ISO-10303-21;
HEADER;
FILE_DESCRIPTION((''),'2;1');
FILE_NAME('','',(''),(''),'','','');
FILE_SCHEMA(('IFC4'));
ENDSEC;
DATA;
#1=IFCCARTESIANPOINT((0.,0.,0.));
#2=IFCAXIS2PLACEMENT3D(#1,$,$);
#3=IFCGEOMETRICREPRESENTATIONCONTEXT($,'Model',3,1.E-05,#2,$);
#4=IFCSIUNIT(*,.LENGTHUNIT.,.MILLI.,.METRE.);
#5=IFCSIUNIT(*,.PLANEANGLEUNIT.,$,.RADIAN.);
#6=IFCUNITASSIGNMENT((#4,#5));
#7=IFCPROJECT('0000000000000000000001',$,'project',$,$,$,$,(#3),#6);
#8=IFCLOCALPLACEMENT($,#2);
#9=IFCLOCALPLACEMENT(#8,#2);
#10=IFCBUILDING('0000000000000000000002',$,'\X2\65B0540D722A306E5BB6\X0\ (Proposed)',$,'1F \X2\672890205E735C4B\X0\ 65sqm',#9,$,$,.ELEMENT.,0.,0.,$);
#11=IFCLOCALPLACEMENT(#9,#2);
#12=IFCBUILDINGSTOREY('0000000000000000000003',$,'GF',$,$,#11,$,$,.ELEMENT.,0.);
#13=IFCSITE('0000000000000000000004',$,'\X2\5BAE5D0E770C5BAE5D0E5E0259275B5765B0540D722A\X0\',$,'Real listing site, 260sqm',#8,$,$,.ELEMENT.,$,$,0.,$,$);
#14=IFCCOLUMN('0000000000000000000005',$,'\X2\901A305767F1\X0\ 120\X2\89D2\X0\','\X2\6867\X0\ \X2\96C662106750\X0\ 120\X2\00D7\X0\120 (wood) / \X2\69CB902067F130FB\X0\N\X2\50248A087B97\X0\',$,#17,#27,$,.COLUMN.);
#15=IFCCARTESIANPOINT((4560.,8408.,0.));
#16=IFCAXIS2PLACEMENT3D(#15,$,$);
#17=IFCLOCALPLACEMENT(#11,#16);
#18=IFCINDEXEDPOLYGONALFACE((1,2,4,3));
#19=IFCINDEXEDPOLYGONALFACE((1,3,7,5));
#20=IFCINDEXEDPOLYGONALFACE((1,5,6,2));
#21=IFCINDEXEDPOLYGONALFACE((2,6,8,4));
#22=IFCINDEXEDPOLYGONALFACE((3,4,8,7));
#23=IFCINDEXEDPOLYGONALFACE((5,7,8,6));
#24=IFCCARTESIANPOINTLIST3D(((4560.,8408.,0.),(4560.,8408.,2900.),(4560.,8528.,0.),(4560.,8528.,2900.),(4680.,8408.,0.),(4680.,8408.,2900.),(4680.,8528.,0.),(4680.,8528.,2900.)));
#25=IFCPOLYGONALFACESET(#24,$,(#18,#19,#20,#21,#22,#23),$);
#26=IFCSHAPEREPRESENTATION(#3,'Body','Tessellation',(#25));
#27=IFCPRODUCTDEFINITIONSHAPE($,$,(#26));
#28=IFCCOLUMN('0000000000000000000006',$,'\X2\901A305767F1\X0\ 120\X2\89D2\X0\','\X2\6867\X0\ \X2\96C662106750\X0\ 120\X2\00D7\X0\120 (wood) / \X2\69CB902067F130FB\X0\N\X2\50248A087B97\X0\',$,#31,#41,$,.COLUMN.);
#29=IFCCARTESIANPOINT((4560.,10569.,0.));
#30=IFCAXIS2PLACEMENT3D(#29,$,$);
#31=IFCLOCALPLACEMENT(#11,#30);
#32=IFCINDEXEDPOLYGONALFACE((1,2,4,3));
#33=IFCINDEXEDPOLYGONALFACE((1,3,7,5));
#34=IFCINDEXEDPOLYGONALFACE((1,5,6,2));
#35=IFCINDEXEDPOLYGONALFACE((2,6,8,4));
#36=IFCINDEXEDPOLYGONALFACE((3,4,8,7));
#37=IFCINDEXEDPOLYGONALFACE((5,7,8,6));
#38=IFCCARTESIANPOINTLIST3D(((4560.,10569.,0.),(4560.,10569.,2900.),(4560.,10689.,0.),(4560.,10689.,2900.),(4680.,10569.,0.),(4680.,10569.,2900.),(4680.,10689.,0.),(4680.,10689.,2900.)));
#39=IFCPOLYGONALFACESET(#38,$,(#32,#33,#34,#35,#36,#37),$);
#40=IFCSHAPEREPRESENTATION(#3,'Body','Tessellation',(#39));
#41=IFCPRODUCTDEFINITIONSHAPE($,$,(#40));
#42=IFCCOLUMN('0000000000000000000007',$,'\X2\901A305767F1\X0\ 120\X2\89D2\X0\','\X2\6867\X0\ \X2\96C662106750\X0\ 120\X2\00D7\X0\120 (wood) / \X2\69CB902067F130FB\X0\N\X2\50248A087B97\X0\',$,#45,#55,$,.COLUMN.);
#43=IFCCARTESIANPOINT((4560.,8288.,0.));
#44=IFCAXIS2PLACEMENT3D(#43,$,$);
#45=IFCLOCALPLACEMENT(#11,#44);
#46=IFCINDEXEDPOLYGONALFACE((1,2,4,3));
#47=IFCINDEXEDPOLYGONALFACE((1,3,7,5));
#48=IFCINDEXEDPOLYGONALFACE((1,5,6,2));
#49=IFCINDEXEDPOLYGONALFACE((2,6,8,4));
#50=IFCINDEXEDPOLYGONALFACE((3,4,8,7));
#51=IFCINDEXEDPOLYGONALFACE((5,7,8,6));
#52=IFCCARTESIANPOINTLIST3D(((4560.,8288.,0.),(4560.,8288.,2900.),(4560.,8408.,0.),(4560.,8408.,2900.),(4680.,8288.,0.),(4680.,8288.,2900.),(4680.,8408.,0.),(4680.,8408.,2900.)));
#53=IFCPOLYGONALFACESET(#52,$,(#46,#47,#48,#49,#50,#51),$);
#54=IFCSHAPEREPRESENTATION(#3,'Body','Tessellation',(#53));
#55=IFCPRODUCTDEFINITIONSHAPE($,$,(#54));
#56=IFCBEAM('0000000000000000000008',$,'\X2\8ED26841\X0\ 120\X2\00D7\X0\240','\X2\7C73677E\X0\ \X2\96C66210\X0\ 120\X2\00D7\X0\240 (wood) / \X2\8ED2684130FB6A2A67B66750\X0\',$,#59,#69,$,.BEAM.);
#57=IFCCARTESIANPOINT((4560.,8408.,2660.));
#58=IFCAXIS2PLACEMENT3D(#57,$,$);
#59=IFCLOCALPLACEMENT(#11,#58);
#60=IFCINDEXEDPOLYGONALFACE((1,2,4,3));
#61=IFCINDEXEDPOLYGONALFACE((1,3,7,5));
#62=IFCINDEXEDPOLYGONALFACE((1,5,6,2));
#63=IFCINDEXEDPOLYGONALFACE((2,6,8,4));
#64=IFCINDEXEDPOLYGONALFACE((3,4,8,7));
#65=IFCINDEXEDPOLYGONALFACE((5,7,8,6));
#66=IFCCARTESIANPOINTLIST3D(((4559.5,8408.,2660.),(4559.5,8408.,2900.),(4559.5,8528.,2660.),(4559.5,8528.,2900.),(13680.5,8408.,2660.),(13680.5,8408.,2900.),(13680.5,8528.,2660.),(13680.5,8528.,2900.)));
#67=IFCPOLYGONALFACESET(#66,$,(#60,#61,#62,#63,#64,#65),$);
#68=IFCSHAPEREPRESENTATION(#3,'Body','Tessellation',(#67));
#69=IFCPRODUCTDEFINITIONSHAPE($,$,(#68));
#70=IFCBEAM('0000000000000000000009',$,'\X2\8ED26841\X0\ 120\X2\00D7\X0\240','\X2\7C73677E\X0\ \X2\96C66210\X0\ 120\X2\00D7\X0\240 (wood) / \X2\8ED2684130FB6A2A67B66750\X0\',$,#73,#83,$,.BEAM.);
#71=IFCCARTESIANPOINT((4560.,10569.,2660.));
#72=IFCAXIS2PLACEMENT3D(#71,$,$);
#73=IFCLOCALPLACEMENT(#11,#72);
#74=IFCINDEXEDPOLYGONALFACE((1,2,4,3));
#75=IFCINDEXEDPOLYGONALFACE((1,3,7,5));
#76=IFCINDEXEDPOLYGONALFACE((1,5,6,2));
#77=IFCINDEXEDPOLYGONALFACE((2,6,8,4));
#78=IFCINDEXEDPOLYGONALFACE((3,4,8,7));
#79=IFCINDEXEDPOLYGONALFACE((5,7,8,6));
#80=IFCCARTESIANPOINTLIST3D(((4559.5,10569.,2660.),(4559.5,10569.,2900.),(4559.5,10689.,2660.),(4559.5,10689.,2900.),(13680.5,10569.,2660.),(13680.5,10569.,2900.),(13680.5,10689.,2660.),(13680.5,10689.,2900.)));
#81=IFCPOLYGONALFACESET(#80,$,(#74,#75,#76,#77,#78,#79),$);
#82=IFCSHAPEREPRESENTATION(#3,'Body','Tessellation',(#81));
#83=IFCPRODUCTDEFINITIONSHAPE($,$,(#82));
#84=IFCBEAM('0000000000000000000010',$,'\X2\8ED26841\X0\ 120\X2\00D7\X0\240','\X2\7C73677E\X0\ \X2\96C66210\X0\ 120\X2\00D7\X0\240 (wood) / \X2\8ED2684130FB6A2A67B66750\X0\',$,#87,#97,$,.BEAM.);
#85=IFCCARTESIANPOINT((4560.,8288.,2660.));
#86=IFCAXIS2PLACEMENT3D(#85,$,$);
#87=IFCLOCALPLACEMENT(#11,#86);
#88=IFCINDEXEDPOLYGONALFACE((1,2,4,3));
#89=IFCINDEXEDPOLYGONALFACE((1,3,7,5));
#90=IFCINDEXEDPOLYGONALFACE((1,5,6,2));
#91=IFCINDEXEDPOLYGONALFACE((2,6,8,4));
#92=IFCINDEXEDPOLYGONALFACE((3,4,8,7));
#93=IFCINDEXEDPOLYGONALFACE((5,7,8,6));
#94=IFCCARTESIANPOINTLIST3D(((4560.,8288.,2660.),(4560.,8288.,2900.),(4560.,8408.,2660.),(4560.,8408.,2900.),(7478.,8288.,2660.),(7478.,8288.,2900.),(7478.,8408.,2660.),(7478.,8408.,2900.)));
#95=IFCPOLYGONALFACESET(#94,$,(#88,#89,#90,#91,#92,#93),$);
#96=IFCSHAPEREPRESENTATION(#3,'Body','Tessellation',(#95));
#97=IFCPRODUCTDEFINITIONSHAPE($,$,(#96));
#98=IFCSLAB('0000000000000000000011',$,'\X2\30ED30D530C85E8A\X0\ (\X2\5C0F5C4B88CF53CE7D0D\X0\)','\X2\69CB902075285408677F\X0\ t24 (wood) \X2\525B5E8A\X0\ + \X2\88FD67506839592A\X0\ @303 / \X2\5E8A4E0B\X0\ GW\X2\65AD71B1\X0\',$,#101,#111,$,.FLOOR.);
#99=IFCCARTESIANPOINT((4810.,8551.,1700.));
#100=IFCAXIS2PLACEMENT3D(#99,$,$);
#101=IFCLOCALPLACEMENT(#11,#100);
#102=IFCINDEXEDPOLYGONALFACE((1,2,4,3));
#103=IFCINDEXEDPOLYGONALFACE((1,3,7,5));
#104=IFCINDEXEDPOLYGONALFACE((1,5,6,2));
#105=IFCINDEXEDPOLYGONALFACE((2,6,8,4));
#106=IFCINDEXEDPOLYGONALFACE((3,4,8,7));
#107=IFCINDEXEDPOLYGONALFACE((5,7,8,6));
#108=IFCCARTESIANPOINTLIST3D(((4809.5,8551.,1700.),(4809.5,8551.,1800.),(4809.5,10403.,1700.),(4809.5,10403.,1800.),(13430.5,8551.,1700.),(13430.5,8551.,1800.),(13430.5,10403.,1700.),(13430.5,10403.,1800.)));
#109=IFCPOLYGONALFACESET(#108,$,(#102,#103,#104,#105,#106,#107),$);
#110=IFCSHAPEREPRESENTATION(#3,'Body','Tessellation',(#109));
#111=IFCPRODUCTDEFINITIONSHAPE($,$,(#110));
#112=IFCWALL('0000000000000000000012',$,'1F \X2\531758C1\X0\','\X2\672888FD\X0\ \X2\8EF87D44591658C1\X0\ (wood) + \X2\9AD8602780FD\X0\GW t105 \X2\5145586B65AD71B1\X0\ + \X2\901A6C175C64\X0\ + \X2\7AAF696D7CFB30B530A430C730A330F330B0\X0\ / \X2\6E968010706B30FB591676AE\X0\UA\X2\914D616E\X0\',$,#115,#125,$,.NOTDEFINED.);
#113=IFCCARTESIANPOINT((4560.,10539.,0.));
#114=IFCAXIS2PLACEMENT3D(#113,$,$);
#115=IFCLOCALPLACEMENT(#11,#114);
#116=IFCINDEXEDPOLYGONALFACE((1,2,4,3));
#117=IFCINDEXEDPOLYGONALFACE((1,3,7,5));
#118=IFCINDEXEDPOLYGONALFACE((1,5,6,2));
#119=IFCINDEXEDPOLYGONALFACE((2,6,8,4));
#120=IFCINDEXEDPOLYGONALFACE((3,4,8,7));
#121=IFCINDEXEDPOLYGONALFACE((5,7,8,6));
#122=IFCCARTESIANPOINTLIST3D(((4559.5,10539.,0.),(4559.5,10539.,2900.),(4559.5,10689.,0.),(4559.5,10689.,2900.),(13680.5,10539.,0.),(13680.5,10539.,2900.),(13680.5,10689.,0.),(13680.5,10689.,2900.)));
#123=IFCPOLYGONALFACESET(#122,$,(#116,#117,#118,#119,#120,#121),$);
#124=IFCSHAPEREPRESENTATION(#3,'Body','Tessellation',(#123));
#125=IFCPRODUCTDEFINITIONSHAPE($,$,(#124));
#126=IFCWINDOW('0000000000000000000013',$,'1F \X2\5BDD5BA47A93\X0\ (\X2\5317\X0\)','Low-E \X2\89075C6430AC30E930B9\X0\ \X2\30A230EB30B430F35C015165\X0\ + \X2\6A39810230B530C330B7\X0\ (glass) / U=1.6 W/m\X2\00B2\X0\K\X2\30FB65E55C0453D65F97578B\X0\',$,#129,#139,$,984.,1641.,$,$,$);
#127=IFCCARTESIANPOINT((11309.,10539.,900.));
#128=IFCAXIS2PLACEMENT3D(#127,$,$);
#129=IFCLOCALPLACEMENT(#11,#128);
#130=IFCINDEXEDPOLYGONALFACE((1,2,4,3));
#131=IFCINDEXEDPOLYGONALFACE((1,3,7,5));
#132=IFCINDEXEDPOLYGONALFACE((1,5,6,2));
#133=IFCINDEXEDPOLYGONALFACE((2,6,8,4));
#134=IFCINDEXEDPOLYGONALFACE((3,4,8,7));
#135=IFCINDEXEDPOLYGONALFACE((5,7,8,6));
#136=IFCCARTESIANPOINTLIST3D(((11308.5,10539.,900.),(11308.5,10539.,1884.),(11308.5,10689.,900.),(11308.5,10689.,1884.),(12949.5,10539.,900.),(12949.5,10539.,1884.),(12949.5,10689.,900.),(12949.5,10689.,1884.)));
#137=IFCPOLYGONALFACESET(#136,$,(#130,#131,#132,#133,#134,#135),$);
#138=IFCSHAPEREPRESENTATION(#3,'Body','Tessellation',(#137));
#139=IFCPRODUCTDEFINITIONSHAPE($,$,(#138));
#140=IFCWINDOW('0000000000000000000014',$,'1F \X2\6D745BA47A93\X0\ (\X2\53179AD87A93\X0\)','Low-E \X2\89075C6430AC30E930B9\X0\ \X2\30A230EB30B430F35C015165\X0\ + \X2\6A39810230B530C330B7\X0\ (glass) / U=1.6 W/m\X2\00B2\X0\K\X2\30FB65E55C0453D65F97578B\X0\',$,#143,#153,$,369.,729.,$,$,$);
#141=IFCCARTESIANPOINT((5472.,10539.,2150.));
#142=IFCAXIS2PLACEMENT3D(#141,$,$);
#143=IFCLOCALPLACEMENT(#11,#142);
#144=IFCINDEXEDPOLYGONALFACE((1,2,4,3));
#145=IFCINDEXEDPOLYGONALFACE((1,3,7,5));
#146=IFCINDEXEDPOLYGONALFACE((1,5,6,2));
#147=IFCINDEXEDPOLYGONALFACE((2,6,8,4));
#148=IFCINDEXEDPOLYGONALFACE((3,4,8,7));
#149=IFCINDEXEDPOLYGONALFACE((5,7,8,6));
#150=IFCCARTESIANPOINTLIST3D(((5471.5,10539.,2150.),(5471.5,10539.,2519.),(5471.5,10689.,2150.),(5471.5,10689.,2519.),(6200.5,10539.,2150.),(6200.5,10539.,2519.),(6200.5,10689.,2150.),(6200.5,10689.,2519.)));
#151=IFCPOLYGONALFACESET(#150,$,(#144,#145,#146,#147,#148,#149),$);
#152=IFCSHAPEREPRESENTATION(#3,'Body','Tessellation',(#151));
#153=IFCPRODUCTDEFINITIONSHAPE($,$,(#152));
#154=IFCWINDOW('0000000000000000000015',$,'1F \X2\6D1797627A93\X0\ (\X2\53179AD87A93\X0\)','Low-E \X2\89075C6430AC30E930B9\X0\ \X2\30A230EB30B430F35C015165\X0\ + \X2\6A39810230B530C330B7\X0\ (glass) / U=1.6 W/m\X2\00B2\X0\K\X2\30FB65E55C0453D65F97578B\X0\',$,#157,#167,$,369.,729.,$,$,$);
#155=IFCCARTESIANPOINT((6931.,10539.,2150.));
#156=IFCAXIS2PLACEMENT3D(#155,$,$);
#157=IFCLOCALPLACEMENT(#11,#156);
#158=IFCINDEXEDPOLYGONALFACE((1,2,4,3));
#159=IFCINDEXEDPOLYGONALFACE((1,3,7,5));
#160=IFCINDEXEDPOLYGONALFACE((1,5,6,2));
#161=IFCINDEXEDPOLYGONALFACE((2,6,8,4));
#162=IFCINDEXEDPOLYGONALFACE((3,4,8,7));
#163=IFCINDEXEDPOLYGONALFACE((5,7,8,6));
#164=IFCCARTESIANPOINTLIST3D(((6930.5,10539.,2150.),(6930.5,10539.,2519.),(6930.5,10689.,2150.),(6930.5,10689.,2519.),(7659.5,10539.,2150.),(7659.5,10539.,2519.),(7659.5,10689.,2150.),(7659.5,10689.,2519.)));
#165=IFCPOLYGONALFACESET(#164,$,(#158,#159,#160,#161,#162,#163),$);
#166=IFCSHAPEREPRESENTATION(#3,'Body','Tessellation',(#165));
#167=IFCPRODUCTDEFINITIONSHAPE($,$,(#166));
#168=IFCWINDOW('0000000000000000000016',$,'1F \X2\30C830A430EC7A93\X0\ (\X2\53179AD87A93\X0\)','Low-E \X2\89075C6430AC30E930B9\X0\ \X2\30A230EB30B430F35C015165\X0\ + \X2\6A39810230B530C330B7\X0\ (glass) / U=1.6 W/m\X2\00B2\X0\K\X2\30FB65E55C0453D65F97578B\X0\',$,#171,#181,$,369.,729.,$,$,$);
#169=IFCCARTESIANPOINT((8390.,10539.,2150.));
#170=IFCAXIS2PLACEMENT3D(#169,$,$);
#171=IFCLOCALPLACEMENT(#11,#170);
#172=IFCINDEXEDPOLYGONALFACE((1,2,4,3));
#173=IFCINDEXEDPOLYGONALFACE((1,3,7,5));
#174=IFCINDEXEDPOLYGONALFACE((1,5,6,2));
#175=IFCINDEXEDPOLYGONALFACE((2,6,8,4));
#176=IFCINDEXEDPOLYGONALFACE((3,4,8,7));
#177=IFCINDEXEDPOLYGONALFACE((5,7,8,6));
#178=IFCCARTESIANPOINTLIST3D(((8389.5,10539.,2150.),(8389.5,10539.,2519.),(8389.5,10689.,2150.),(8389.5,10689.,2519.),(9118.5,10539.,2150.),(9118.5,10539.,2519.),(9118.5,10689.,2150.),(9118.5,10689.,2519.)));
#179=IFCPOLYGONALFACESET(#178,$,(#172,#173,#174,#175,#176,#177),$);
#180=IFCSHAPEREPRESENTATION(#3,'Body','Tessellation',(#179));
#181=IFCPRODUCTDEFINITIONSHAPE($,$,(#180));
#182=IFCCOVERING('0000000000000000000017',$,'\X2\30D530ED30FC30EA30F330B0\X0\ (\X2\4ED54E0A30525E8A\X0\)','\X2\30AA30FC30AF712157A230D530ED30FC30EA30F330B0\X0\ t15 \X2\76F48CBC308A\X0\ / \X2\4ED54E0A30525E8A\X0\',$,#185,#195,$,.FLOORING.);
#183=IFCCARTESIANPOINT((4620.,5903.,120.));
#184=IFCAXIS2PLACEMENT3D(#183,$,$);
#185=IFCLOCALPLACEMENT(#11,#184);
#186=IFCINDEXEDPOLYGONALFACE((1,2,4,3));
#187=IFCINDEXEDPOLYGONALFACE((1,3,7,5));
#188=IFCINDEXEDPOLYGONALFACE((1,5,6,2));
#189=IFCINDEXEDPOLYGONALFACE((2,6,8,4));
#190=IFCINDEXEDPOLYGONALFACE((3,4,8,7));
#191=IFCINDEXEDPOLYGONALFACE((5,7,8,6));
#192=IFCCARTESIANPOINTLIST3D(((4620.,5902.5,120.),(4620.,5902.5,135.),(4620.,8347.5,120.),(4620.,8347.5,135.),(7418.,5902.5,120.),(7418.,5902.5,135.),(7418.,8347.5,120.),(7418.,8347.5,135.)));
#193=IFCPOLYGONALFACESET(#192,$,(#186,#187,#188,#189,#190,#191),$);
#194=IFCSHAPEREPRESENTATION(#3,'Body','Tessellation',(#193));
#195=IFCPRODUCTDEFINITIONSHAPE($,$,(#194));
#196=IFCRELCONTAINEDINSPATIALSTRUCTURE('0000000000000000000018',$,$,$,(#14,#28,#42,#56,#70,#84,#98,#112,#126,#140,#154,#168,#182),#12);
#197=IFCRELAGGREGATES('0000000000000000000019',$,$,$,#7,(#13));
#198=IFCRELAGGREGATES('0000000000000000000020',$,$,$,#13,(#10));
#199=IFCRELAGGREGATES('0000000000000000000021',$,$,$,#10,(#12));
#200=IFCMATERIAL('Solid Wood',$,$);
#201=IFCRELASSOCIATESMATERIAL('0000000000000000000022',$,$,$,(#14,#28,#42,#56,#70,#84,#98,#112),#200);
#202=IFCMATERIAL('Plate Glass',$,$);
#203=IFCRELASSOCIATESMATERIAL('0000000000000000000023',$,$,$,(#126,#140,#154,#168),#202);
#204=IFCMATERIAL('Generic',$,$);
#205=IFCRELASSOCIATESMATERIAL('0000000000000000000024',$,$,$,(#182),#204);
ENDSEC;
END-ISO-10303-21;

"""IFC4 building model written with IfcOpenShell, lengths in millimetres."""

from ifc_helpers import new_model, si_unit, frame, frame_2d, origin, place, context, project, spatial, rectangle, extrude, material, element, fill, save


model = new_model("IFC4")

# Units and contexts
model_context = context("Model", 3, precision=1e-05, world=origin())
ifc_project = project(units=[si_unit("LENGTHUNIT", "METRE", prefix="MILLI"), si_unit("PLANEANGLEUNIT", "RADIAN")], contexts=[model_context])

# Site, building, storey
site_placement = place(None, origin())
site = spatial("IfcSite", under=ifc_project, at=site_placement, Name="宮崎県宮崎市大字新名爪", ObjectType="Real listing site, 260sqm", CompositionType="ELEMENT", RefElevation=0.0)
building_placement = place(site_placement, origin())
building = spatial("IfcBuilding", under=site, at=building_placement, Name="新名爪の家 (Proposed)", ObjectType="1F 木造平屋 65sqm", CompositionType="ELEMENT", ElevationOfRefHeight=0.0, ElevationOfTerrain=0.0)
storey_placement = place(building_placement, origin())
storey = spatial("IfcBuildingStorey", under=building, at=storey_placement, Name="GF", CompositionType="ELEMENT", Elevation=0.0)

# Columns
ifc_material_1 = material(Name="Solid Wood")
column_1_placement = place(storey_placement, frame((4560.0, 8408.0, 0.0)))
element("IfcColumn", 1, at=column_1_placement, inside=storey, material=ifc_material_1, Name="通し柱 120角", Description="桧 集成材 120×120 (wood) / 構造柱・N値計算", PredefinedType="COLUMN", context=model_context, shape_type="SweptSolid", body=[
    extrude(rectangle(XDim=120.0, YDim=120.0, at=frame_2d((60.0, 60.0))), frame((4560.0, 8408.0, 0.0)), (0.0, 0.0, 1.0), 2900.0),
])
column_2_placement = place(storey_placement, frame((4560.0, 10569.0, 0.0)))
element("IfcColumn", 2, at=column_2_placement, inside=storey, material=ifc_material_1, Name="通し柱 120角", Description="桧 集成材 120×120 (wood) / 構造柱・N値計算", PredefinedType="COLUMN", context=model_context, shape_type="SweptSolid", body=[
    extrude(rectangle(XDim=120.0, YDim=120.0, at=frame_2d((60.0, 60.0))), frame((4560.0, 10569.0, 0.0)), (0.0, 0.0, 1.0), 2900.0),
])
column_3_placement = place(storey_placement, frame((4560.0, 8288.0, 0.0)))
element("IfcColumn", 3, at=column_3_placement, inside=storey, material=ifc_material_1, Name="通し柱 120角", Description="桧 集成材 120×120 (wood) / 構造柱・N値計算", PredefinedType="COLUMN", context=model_context, shape_type="SweptSolid", body=[
    extrude(rectangle(XDim=120.0, YDim=120.0, at=frame_2d((60.0, 60.0))), frame((4560.0, 8288.0, 0.0)), (0.0, 0.0, 1.0), 2900.0),
])

# Beams
beam_1_placement = place(storey_placement, frame((4560.0, 8408.0, 2660.0)))
element("IfcBeam", 4, at=beam_1_placement, inside=storey, material=ifc_material_1, Name="軒桁 120×240", Description="米松 集成 120×240 (wood) / 軒桁・横架材", PredefinedType="BEAM", context=model_context, shape_type="SweptSolid", body=[
    extrude(rectangle(XDim=9121.0, YDim=120.0, at=frame_2d((4560.0, 60.0))), frame((4560.0, 8408.0, 2660.0)), (0.0, 0.0, 1.0), 240.0),
])
beam_2_placement = place(storey_placement, frame((4560.0, 10569.0, 2660.0)))
element("IfcBeam", 5, at=beam_2_placement, inside=storey, material=ifc_material_1, Name="軒桁 120×240", Description="米松 集成 120×240 (wood) / 軒桁・横架材", PredefinedType="BEAM", context=model_context, shape_type="SweptSolid", body=[
    extrude(rectangle(XDim=9121.0, YDim=120.0, at=frame_2d((4560.0, 60.0))), frame((4560.0, 10569.0, 2660.0)), (0.0, 0.0, 1.0), 240.0),
])
beam_3_placement = place(storey_placement, frame((4560.0, 8288.0, 2660.0)))
element("IfcBeam", 6, at=beam_3_placement, inside=storey, material=ifc_material_1, Name="軒桁 120×240", Description="米松 集成 120×240 (wood) / 軒桁・横架材", PredefinedType="BEAM", context=model_context, shape_type="SweptSolid", body=[
    extrude(rectangle(XDim=2918.0, YDim=120.0, at=frame_2d((1459.0, 60.0))), frame((4560.0, 8288.0, 2660.0)), (0.0, 0.0, 1.0), 240.0),
])

# Slab
slab_1_placement = place(storey_placement, frame((4810.0, 8551.0, 1700.0)))
element("IfcSlab", 7, at=slab_1_placement, inside=storey, material=ifc_material_1, Name="ロフト床 (小屋裏収納)", Description="構造用合板 t24 (wood) 剛床 + 製材根太 @303 / 床下 GW断熱", PredefinedType="FLOOR", context=model_context, shape_type="SweptSolid", body=[
    extrude(rectangle(XDim=8621.0, YDim=1852.0, at=frame_2d((4310.0, 926.0))), frame((4810.0, 8551.0, 1700.0)), (0.0, 0.0, 1.0), 100.0),
])

# Wall, openings, windows
wall_1_placement = place(storey_placement, frame((4560.0, 10539.0, 0.0)))
wall_1 = element("IfcWall", 8, at=wall_1_placement, inside=storey, material=ifc_material_1, Name="1F 北壁", Description="木製 軸組外壁 (wood) + 高性能GW t105 充填断熱 + 通気層 + 窯業系サイディング / 準耐火・外皮UA配慮", PredefinedType="NOTDEFINED", context=model_context, shape_type="SweptSolid", body=[
    extrude(rectangle(XDim=9121.0, YDim=150.0, at=frame_2d((4560.0, 75.0))), frame((4560.0, 10539.0, 0.0)), (0.0, 0.0, 1.0), 2900.0),
])
opening_1_placement = place(storey_placement, frame((11309.0, 10539.0, 900.0)))
opening_1 = element("IfcOpeningElement", 9, at=opening_1_placement, cuts=wall_1, PredefinedType="NOTDEFINED", context=model_context, shape_type="SweptSolid", body=[
    extrude(rectangle(XDim=1641.0, YDim=150.0, at=frame_2d((820.0, 75.0))), frame((11309.0, 10539.0, 900.0)), (0.0, 0.0, 1.0), 984.0),
])
opening_2_placement = place(storey_placement, frame((5472.0, 10539.0, 2150.0)))
opening_2 = element("IfcOpeningElement", 10, at=opening_2_placement, cuts=wall_1, PredefinedType="NOTDEFINED", context=model_context, shape_type="SweptSolid", body=[
    extrude(rectangle(XDim=729.0, YDim=150.0, at=frame_2d((364.0, 75.0))), frame((5472.0, 10539.0, 2150.0)), (0.0, 0.0, 1.0), 369.0),
])
opening_3_placement = place(storey_placement, frame((6931.0, 10539.0, 2150.0)))
opening_3 = element("IfcOpeningElement", 11, at=opening_3_placement, cuts=wall_1, PredefinedType="NOTDEFINED", context=model_context, shape_type="SweptSolid", body=[
    extrude(rectangle(XDim=729.0, YDim=150.0, at=frame_2d((364.0, 75.0))), frame((6931.0, 10539.0, 2150.0)), (0.0, 0.0, 1.0), 369.0),
])
opening_4_placement = place(storey_placement, frame((8390.0, 10539.0, 2150.0)))
opening_4 = element("IfcOpeningElement", 12, at=opening_4_placement, cuts=wall_1, PredefinedType="NOTDEFINED", context=model_context, shape_type="SweptSolid", body=[
    extrude(rectangle(XDim=729.0, YDim=150.0, at=frame_2d((364.0, 75.0))), frame((8390.0, 10539.0, 2150.0)), (0.0, 0.0, 1.0), 369.0),
])
ifc_material_2 = material(Name="Plate Glass")
window_1_placement = place(storey_placement, frame((11309.0, 10539.0, 900.0)))
window_1 = element("IfcWindow", 13, at=window_1_placement, inside=storey, material=ifc_material_2, Name="1F 寝室窓 (北)", Description="Low-E 複層ガラス アルゴン封入 + 樹脂サッシ (glass) / U=1.6 W/m²K・日射取得型", OverallHeight=984.0, OverallWidth=1641.0, context=model_context, shape_type="SweptSolid", body=[
    extrude(rectangle(XDim=1641.0, YDim=150.0, at=frame_2d((820.0, 75.0))), frame((11309.0, 10539.0, 900.0)), (0.0, 0.0, 1.0), 984.0),
])
fill(opening_1, window_1)
window_2_placement = place(storey_placement, frame((5472.0, 10539.0, 2150.0)))
window_2 = element("IfcWindow", 14, at=window_2_placement, inside=storey, material=ifc_material_2, Name="1F 浴室窓 (北高窓)", Description="Low-E 複層ガラス アルゴン封入 + 樹脂サッシ (glass) / U=1.6 W/m²K・日射取得型", OverallHeight=369.0, OverallWidth=729.0, context=model_context, shape_type="SweptSolid", body=[
    extrude(rectangle(XDim=729.0, YDim=150.0, at=frame_2d((364.0, 75.0))), frame((5472.0, 10539.0, 2150.0)), (0.0, 0.0, 1.0), 369.0),
])
fill(opening_2, window_2)
window_3_placement = place(storey_placement, frame((6931.0, 10539.0, 2150.0)))
window_3 = element("IfcWindow", 15, at=window_3_placement, inside=storey, material=ifc_material_2, Name="1F 洗面窓 (北高窓)", Description="Low-E 複層ガラス アルゴン封入 + 樹脂サッシ (glass) / U=1.6 W/m²K・日射取得型", OverallHeight=369.0, OverallWidth=729.0, context=model_context, shape_type="SweptSolid", body=[
    extrude(rectangle(XDim=729.0, YDim=150.0, at=frame_2d((364.0, 75.0))), frame((6931.0, 10539.0, 2150.0)), (0.0, 0.0, 1.0), 369.0),
])
fill(opening_3, window_3)
window_4_placement = place(storey_placement, frame((8390.0, 10539.0, 2150.0)))
window_4 = element("IfcWindow", 16, at=window_4_placement, inside=storey, material=ifc_material_2, Name="1F トイレ窓 (北高窓)", Description="Low-E 複層ガラス アルゴン封入 + 樹脂サッシ (glass) / U=1.6 W/m²K・日射取得型", OverallHeight=369.0, OverallWidth=729.0, context=model_context, shape_type="SweptSolid", body=[
    extrude(rectangle(XDim=729.0, YDim=150.0, at=frame_2d((364.0, 75.0))), frame((8390.0, 10539.0, 2150.0)), (0.0, 0.0, 1.0), 369.0),
])
fill(opening_4, window_4)

# Covering
ifc_material_3 = material(Name="Generic")
covering_1_placement = place(storey_placement, frame((4620.0, 5903.0, 120.0)))
element("IfcCovering", 17, at=covering_1_placement, inside=storey, material=ifc_material_3, Name="フローリング (仕上げ床)", Description="オーク無垢フローリング t15 直貼り / 仕上げ床", PredefinedType="FLOORING", context=model_context, shape_type="SweptSolid", body=[
    extrude(rectangle(XDim=2798.0, YDim=2445.0, at=frame_2d((1399.0, 1222.0))), frame((4620.0, 5903.0, 120.0)), (0.0, 0.0, 1.0), 15.0),
])

save(model, "model.ifc")
